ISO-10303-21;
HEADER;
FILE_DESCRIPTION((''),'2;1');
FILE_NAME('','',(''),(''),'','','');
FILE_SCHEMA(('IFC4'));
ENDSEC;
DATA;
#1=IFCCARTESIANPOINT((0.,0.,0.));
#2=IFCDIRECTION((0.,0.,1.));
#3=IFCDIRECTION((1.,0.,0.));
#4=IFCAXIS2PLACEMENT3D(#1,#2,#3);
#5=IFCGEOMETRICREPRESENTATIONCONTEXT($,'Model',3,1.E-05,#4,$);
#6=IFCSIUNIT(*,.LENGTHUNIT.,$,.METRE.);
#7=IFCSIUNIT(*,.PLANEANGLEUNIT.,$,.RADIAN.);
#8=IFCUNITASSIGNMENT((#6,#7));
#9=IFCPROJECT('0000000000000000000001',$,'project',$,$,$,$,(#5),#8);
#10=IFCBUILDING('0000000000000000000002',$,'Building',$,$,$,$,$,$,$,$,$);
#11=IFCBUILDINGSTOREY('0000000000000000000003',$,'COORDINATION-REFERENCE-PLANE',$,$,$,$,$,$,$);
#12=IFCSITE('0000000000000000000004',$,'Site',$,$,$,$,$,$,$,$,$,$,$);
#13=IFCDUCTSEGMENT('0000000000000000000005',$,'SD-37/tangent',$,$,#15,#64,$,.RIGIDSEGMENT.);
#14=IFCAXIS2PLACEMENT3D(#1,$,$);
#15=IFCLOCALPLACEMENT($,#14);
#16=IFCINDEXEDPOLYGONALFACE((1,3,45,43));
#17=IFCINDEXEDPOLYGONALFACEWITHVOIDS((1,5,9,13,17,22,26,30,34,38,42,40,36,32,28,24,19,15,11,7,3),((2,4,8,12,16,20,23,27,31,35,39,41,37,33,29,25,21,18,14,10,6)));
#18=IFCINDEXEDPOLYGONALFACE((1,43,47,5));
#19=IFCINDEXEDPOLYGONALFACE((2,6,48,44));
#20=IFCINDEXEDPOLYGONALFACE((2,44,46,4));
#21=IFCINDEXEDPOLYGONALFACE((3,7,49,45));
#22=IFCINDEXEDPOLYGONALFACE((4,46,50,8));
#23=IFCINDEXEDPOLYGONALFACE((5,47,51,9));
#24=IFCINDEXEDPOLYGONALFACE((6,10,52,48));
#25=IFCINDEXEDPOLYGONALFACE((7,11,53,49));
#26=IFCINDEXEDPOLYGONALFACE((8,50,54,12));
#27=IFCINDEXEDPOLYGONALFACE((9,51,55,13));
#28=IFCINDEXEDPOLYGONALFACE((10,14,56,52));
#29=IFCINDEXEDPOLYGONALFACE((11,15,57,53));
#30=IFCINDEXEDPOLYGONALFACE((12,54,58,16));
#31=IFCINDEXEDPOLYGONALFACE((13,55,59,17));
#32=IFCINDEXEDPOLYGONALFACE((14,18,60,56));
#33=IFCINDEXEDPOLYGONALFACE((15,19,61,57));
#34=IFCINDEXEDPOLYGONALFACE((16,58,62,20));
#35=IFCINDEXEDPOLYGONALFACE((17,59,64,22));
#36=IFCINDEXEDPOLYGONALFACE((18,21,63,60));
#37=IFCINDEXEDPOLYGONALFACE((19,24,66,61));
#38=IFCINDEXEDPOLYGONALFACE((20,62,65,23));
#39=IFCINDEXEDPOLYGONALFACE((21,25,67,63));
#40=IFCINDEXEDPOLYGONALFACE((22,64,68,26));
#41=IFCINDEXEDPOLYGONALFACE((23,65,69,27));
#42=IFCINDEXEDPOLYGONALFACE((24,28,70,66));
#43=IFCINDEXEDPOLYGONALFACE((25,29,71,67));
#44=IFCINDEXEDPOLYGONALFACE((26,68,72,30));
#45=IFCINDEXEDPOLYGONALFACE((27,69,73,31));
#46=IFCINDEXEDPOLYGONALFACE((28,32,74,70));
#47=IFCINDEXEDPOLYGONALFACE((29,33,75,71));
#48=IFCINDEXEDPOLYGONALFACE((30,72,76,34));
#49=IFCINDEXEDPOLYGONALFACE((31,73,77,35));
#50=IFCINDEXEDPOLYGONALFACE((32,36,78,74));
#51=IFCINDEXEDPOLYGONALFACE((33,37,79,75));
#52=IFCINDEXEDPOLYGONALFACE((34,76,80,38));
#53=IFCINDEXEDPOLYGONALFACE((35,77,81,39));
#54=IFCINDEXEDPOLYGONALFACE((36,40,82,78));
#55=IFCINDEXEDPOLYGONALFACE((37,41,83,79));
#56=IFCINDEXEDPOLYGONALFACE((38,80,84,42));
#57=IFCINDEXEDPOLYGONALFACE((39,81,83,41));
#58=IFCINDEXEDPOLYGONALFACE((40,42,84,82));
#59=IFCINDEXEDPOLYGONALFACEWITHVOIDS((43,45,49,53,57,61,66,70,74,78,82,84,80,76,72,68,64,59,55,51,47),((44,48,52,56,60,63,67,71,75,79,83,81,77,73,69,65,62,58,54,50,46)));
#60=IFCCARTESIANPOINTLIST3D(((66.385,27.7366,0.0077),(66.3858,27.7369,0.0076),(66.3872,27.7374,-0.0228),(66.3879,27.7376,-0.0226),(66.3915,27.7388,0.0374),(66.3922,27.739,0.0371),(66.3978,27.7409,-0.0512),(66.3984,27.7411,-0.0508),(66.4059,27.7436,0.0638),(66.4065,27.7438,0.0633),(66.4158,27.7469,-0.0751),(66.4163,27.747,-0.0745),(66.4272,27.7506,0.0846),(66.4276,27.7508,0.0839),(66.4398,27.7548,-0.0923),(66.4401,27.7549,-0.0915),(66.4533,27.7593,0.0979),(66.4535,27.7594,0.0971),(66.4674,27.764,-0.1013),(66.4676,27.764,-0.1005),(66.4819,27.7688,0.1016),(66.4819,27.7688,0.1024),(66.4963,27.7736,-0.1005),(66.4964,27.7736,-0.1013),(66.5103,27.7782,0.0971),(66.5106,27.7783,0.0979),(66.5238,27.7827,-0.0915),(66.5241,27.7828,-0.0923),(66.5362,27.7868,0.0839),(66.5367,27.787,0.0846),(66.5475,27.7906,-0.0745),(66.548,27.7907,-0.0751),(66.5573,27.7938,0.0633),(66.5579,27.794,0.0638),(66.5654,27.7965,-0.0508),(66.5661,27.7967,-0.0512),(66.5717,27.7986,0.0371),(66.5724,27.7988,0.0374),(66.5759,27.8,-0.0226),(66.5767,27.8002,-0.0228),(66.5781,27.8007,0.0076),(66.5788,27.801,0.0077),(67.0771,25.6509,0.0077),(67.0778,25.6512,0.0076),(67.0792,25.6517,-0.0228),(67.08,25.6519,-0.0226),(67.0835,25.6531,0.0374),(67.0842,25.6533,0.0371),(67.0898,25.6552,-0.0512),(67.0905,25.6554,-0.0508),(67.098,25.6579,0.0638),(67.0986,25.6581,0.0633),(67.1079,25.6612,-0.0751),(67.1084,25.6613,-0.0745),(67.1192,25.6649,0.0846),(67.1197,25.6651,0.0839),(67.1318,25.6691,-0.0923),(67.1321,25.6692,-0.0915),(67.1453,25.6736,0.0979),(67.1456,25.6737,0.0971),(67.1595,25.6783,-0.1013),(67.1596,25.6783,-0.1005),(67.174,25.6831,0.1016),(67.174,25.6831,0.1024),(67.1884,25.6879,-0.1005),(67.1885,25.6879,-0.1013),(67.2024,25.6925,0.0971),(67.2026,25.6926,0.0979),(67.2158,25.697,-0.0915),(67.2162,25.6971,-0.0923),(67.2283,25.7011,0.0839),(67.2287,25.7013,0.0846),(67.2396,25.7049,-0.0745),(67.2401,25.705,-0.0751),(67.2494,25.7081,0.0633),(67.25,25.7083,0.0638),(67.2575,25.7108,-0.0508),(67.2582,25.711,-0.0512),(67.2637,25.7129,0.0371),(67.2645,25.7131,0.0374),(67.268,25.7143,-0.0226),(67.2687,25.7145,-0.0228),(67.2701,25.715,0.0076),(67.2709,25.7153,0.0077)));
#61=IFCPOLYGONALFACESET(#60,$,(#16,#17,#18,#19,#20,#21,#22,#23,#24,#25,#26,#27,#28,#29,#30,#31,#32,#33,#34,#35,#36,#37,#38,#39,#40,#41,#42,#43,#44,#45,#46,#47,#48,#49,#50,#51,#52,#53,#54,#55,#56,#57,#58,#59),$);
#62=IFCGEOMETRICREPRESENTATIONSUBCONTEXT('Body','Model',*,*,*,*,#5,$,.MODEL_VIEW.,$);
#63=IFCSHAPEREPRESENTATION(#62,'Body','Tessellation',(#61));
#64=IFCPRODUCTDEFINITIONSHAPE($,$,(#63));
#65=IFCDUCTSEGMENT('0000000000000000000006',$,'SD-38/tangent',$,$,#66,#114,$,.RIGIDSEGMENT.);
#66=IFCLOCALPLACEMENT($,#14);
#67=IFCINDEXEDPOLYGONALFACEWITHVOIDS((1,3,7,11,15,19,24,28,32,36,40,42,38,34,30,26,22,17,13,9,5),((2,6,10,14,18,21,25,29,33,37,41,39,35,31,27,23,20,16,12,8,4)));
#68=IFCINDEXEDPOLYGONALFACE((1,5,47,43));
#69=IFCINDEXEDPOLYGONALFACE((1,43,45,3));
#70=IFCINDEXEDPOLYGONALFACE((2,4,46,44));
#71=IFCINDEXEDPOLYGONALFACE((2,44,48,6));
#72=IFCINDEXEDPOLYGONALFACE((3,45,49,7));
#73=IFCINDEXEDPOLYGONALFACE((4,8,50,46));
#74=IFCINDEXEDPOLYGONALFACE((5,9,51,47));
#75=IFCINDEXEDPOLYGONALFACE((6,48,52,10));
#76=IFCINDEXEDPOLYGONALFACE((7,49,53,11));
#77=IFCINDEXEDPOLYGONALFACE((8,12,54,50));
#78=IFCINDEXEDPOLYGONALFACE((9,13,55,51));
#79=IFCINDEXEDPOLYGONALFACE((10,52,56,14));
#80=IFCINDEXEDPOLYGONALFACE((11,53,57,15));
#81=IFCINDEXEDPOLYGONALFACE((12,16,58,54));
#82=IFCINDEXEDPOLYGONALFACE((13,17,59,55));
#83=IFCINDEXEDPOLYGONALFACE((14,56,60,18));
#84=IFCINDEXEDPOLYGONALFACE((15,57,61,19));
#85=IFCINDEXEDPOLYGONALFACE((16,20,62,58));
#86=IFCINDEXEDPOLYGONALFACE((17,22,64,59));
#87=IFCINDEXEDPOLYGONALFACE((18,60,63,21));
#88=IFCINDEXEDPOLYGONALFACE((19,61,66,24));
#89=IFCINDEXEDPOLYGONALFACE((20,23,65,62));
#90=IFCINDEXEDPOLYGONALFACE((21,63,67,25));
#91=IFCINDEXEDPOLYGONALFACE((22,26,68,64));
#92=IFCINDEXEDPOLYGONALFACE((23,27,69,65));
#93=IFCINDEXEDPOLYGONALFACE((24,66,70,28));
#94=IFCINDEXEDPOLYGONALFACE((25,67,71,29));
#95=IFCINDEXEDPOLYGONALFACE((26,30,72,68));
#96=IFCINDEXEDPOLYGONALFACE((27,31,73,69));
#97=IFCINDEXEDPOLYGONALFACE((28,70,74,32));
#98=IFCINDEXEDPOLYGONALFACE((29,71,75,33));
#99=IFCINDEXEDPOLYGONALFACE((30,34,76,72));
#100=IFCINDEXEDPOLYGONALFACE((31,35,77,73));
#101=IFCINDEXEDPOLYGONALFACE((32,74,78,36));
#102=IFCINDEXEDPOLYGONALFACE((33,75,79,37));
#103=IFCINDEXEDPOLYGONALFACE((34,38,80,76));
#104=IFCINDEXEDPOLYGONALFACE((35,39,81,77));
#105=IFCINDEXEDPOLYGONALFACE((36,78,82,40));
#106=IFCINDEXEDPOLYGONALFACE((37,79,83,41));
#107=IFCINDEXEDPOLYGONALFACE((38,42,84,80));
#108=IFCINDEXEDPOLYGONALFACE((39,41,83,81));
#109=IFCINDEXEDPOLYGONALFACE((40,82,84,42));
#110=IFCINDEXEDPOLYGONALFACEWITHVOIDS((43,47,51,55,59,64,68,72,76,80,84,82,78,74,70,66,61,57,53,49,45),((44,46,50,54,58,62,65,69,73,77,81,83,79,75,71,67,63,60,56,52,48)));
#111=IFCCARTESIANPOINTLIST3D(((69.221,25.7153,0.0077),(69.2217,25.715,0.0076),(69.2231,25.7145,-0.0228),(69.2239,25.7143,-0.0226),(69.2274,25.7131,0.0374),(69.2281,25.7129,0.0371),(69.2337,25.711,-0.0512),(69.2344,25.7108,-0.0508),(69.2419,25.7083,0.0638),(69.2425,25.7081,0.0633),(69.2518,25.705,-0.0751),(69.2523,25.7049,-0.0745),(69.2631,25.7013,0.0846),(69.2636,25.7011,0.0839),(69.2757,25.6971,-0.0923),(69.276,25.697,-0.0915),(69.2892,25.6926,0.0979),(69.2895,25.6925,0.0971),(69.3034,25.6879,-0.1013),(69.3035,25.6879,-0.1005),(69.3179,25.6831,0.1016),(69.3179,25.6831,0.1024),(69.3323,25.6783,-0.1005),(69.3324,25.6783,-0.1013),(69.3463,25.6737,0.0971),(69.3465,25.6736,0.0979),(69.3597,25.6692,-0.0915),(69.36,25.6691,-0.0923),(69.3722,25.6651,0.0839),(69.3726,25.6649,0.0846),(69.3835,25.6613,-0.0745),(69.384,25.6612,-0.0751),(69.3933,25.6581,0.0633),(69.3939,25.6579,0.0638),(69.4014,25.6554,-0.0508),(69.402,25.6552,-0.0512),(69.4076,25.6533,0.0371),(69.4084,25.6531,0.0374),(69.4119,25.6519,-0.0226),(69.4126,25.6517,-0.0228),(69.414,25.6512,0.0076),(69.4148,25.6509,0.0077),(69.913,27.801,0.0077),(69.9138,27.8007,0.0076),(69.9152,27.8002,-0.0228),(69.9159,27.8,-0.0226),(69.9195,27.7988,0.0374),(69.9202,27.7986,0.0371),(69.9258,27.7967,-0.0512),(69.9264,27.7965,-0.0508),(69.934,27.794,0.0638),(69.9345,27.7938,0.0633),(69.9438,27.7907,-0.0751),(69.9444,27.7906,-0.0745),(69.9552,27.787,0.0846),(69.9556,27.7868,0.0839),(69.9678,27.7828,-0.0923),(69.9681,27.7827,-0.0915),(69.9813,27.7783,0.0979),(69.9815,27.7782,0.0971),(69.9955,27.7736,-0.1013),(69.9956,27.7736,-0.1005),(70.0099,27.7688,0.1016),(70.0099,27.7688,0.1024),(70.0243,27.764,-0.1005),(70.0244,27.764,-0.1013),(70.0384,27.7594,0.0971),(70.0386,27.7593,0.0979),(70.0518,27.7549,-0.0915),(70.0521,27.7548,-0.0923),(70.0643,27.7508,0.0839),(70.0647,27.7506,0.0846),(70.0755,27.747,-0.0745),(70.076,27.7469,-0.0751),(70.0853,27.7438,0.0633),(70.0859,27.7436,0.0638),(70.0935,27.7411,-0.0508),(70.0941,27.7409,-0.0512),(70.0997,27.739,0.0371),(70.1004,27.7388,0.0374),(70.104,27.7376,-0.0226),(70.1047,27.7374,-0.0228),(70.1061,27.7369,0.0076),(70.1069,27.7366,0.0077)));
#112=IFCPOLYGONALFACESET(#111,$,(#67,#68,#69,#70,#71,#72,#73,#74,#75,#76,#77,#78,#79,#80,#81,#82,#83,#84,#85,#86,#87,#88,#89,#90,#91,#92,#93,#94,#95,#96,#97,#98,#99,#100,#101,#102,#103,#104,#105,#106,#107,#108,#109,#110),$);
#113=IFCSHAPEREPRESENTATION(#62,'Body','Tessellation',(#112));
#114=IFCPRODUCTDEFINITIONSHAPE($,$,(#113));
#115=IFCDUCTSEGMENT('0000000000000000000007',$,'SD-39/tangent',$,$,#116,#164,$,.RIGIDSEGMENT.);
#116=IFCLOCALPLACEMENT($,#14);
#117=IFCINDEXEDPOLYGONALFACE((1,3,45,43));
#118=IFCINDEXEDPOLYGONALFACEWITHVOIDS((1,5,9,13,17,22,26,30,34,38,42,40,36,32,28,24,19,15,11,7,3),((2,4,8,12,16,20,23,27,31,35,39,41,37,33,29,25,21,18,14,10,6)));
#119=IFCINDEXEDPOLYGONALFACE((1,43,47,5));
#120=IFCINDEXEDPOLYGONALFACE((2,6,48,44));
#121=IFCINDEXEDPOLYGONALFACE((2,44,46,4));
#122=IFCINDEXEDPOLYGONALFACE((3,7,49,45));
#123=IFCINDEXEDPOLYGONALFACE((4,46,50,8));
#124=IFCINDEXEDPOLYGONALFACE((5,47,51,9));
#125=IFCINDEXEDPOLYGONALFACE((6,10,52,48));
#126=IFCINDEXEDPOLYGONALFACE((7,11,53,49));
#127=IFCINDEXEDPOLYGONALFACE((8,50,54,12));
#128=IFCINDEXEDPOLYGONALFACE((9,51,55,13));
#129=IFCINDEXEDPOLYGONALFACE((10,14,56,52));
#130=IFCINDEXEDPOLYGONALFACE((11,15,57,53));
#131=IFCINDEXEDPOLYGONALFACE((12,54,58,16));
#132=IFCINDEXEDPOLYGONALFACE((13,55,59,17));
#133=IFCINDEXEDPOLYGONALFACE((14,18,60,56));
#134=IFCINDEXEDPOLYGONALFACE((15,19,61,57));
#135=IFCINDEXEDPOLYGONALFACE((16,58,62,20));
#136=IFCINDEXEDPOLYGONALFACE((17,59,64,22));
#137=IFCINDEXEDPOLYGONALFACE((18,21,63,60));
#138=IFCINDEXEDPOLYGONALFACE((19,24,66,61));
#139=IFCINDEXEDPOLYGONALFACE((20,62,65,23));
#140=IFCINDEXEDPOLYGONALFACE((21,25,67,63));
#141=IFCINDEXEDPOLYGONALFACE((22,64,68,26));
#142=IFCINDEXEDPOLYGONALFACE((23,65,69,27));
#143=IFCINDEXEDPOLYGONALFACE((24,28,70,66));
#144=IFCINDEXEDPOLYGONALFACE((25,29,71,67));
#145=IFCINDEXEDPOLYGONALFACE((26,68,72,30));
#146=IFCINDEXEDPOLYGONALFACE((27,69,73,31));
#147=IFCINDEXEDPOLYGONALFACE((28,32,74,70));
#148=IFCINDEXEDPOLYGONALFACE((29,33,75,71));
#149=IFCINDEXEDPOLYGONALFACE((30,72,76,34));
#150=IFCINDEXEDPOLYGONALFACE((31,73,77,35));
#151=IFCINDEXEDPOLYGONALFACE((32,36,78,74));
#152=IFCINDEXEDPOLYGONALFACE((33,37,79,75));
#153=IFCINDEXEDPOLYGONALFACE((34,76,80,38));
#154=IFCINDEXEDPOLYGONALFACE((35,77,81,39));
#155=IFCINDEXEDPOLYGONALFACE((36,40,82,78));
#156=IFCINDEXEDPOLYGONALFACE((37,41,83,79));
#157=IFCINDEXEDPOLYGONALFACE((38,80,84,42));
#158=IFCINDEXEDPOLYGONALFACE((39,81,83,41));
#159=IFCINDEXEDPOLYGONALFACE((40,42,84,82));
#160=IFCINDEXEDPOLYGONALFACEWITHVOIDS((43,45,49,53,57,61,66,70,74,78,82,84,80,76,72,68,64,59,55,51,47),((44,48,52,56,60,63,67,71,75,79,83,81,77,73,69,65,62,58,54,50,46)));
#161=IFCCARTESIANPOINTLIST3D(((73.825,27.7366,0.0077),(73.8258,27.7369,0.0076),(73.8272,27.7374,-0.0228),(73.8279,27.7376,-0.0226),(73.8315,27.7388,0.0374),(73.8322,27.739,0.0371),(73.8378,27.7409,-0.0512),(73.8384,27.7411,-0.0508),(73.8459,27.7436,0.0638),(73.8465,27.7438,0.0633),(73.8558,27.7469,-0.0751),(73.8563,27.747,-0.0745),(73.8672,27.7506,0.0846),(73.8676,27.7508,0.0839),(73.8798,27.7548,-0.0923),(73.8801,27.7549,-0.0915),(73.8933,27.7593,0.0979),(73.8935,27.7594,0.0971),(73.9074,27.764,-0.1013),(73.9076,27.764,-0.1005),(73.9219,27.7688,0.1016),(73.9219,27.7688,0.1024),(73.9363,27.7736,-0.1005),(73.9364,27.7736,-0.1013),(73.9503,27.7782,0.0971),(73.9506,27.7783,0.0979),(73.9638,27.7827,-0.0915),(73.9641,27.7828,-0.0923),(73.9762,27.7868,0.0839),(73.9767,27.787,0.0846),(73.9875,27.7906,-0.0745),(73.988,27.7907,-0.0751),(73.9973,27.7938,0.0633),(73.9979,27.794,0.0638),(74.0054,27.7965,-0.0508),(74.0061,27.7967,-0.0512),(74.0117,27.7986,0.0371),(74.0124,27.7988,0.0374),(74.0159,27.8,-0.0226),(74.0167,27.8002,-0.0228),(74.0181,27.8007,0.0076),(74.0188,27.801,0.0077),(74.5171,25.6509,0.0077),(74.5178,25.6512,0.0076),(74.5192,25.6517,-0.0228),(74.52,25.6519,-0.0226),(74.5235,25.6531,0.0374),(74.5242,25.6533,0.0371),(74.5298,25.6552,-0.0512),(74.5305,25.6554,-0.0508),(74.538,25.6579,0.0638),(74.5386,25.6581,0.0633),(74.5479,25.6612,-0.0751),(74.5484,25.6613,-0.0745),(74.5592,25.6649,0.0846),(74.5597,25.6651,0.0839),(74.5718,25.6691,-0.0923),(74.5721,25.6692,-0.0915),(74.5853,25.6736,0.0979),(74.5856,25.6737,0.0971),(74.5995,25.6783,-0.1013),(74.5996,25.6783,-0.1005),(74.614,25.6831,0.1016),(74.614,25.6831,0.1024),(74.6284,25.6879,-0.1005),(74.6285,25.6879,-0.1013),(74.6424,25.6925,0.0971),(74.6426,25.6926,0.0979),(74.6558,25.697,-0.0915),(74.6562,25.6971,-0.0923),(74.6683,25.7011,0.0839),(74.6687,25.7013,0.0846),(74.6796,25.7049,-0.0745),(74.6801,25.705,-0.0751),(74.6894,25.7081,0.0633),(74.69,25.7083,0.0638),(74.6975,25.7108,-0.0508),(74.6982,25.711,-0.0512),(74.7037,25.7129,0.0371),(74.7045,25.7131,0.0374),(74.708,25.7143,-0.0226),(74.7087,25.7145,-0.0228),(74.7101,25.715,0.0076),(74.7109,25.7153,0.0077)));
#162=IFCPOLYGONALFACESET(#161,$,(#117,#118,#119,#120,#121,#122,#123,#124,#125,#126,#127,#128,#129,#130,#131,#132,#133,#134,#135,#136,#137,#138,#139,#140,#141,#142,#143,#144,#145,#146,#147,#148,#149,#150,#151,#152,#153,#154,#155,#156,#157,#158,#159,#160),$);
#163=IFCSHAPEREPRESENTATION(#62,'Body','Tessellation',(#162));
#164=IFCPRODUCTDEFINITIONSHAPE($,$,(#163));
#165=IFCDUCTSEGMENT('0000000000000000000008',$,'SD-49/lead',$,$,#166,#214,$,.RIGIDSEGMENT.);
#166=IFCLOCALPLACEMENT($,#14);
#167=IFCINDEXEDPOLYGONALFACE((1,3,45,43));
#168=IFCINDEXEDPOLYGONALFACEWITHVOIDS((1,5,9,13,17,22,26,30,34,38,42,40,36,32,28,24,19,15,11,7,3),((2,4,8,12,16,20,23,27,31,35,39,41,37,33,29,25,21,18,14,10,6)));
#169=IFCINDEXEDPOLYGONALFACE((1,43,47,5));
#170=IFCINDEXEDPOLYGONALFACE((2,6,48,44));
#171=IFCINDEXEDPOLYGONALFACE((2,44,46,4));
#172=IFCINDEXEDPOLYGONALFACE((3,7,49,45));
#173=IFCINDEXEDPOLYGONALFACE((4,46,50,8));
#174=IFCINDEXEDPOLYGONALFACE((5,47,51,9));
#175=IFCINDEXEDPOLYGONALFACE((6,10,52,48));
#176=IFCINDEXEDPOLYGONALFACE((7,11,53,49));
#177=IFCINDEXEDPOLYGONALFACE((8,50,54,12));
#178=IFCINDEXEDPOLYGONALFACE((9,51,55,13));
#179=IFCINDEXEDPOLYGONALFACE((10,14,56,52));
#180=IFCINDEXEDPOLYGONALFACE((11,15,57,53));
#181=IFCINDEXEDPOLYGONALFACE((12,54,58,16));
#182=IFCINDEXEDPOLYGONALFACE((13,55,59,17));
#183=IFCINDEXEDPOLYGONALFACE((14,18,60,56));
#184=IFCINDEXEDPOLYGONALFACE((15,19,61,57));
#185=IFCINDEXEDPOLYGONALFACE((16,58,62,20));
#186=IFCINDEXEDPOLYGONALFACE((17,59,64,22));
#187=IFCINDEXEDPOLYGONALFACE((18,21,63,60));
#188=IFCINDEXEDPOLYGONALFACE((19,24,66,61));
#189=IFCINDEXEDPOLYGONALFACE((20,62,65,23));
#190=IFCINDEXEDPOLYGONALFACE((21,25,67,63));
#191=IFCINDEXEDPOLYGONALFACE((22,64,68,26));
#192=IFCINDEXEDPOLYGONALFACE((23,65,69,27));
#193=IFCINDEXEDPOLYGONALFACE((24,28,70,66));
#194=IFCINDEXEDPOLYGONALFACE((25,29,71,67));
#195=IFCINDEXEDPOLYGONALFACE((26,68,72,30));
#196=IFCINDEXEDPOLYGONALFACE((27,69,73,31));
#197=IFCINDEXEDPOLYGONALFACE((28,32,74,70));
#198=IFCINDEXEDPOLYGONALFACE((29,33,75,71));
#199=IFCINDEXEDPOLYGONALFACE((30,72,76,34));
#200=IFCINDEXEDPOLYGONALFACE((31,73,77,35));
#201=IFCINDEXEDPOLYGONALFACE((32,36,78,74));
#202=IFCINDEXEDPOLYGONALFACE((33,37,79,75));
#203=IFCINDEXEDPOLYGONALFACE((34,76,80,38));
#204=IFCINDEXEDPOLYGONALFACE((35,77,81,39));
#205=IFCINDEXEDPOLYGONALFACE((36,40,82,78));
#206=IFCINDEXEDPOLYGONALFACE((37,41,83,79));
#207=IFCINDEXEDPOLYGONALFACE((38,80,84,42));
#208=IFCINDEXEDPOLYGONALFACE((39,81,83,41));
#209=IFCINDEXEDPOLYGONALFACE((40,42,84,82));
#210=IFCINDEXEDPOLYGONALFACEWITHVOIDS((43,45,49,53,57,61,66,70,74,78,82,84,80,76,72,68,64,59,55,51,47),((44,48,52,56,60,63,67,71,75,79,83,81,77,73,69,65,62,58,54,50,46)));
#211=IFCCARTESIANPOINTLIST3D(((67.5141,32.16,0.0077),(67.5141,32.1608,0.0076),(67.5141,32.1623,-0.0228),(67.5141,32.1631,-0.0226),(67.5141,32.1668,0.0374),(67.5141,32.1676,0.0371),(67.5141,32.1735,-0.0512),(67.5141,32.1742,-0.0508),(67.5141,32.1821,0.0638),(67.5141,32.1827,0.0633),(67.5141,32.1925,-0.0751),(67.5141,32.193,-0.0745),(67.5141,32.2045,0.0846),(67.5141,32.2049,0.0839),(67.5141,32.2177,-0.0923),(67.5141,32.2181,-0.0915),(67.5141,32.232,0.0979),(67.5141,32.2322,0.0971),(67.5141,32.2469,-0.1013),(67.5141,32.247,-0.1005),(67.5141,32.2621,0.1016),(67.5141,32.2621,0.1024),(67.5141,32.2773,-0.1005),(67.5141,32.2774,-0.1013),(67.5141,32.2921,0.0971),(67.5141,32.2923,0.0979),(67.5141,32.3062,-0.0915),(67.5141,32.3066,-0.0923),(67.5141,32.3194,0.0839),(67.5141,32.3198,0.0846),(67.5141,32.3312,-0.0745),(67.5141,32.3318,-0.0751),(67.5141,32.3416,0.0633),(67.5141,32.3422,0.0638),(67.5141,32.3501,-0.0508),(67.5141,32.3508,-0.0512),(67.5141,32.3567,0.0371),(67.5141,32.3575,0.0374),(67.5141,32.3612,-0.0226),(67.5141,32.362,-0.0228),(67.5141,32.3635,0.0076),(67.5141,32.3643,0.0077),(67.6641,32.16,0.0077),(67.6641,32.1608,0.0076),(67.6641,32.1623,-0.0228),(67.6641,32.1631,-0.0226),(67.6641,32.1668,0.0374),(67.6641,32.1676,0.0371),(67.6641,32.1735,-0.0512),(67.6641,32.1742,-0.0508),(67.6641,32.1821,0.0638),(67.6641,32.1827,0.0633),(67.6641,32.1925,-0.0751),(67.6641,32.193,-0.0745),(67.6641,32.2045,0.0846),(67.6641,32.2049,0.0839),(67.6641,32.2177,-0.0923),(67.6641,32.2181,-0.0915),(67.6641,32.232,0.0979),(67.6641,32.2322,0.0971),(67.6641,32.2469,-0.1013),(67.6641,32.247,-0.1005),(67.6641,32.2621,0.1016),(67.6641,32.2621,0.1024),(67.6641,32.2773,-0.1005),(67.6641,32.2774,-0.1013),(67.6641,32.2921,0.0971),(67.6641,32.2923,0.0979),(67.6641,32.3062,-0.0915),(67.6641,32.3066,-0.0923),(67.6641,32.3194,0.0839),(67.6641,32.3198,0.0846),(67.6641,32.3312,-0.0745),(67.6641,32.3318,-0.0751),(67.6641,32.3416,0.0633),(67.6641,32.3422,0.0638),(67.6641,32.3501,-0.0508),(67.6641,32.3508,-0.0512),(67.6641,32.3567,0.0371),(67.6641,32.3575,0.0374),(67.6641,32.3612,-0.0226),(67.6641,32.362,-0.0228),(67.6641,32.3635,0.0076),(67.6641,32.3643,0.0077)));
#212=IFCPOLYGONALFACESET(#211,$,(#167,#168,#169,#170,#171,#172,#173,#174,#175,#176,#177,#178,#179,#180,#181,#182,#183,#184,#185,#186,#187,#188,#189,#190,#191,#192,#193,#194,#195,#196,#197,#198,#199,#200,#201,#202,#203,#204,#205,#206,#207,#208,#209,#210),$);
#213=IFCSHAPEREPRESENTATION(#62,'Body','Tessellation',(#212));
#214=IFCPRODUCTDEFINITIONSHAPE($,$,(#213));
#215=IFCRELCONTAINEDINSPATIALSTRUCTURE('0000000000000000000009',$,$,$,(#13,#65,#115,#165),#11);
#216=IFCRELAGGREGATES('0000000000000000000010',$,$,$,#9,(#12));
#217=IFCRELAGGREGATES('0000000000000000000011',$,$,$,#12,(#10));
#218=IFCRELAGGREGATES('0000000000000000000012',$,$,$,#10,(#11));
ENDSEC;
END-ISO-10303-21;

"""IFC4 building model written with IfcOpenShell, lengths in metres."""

from ifc_helpers import new_model, si_unit, frame, origin_with_axes, place, context, subcontext, project, spatial, hollow_circle, extrude, element, save


model = new_model("IFC4")

# Units and contexts
model_context = context("Model", 3, precision=1e-05, world=origin_with_axes())
body_context_1 = subcontext(model_context, "Body", "Model", "MODEL_VIEW")
ifc_project = project(units=[si_unit("LENGTHUNIT", "METRE"), si_unit("PLANEANGLEUNIT", "RADIAN")], contexts=[model_context])

# Site, building, storey
site = spatial("IfcSite", under=ifc_project, Name="Site")
building = spatial("IfcBuilding", under=site, Name="Building")
storey = spatial("IfcBuildingStorey", under=building, Name="COORDINATION-REFERENCE-PLANE")

# Duct segment
duct_segment_1_placement = place(None, frame((67.174, 25.6831, 0.0), z_axis=(-0.314929, 0.949115, 0.0), x_axis=(0.0, 0.0, 1.0)))
element("IfcDuctSegment", 1, at=duct_segment_1_placement, inside=storey, Name="SD-37/tangent", PredefinedType="RIGIDSEGMENT", context=body_context_1, shape_type="SweptSolid", body=[
    extrude(hollow_circle(Radius=0.1024, WallThickness=0.0008), origin_with_axes(), (0.0, 0.0, 1.0), 2.1975),
])

# Duct segment
duct_segment_2_placement = place(None, frame((69.3179, 25.6831, 0.0), z_axis=(0.314929, 0.949115, 0.0), x_axis=(0.0, 0.0, 1.0)))
element("IfcDuctSegment", 2, at=duct_segment_2_placement, inside=storey, Name="SD-38/tangent", PredefinedType="RIGIDSEGMENT", context=body_context_1, shape_type="SweptSolid", body=[
    extrude(hollow_circle(Radius=0.1024, WallThickness=0.0008), origin_with_axes(), (0.0, 0.0, 1.0), 2.1975),
])

# Duct segment
duct_segment_3_placement = place(None, frame((74.614, 25.6831, 0.0), z_axis=(-0.314929, 0.949115, 0.0), x_axis=(0.0, 0.0, 1.0)))
element("IfcDuctSegment", 3, at=duct_segment_3_placement, inside=storey, Name="SD-39/tangent", PredefinedType="RIGIDSEGMENT", context=body_context_1, shape_type="SweptSolid", body=[
    extrude(hollow_circle(Radius=0.1024, WallThickness=0.0008), origin_with_axes(), (0.0, 0.0, 1.0), 2.1975),
])

# Duct segment
duct_segment_4_placement = place(None, frame((67.6641, 32.2621, 0.0), z_axis=(-1.0, 0.0, 0.0), x_axis=(0.0, 0.0, 1.0)))
element("IfcDuctSegment", 4, at=duct_segment_4_placement, inside=storey, Name="SD-49/lead", PredefinedType="RIGIDSEGMENT", context=body_context_1, shape_type="SweptSolid", body=[
    extrude(hollow_circle(Radius=0.1024, WallThickness=0.0008), origin_with_axes(), (0.0, 0.0, 1.0), 0.15),
])

save(model, "model.ifc")
